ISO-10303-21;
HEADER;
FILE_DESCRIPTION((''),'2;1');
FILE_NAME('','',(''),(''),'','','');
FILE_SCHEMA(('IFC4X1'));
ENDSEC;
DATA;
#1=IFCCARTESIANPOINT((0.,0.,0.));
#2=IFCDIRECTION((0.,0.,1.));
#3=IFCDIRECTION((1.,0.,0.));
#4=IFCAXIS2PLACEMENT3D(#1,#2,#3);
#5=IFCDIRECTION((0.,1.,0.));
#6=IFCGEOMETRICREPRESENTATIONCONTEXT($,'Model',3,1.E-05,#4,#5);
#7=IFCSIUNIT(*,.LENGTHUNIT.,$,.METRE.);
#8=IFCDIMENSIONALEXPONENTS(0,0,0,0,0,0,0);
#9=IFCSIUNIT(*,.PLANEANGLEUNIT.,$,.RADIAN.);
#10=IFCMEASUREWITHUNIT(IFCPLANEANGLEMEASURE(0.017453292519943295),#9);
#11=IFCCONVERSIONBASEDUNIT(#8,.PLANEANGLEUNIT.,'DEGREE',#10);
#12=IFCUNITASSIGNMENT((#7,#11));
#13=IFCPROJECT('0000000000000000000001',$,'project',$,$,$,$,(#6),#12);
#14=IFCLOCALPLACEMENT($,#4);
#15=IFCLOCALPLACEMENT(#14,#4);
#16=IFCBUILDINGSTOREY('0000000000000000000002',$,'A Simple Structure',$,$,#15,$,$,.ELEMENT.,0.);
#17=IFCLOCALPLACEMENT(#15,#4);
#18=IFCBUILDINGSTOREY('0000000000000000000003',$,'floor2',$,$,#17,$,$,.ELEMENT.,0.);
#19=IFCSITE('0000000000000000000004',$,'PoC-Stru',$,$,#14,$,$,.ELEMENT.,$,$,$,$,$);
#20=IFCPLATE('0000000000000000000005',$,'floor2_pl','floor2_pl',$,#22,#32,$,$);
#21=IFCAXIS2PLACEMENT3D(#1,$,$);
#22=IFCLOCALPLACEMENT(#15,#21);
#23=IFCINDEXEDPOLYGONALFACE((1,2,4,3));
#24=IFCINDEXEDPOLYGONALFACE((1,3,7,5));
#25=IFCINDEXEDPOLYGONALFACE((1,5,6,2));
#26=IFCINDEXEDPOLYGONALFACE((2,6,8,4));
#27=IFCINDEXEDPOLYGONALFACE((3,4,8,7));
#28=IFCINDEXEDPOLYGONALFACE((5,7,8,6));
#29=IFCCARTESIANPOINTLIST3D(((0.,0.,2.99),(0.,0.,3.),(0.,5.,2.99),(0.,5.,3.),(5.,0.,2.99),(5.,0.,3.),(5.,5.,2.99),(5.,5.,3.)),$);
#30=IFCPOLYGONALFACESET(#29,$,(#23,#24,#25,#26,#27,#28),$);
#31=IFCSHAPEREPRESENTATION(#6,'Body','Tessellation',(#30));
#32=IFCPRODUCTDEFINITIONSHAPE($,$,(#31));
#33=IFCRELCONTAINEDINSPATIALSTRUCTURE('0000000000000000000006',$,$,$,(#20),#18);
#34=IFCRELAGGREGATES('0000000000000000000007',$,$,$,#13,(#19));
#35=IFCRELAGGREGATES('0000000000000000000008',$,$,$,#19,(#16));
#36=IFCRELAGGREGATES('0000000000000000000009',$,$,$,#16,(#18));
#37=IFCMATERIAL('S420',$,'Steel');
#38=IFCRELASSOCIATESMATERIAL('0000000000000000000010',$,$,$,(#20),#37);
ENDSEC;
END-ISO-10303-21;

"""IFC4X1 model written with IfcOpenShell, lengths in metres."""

from ifc_helpers import new_model, entity, si_unit, converted_unit, direction, origin_with_axes, place, context, project, spatial, line, indexed_curve, outline, extrude, material, element, save


model = new_model("IFC4X1")

# Units and contexts
model_context = context("Model", 3, precision=1e-05, world=origin_with_axes(), true_north=direction((0.0, 1.0, 0.0)))
ifc_project = project(units=[si_unit("LENGTHUNIT", "METRE"), converted_unit("PLANEANGLEUNIT", "DEGREE", entity("IfcPlaneAngleMeasure", 0.017453292519943295), si_unit("PLANEANGLEUNIT", "RADIAN"), dimensions=[0, 0, 0, 0, 0, 0, 0])], contexts=[model_context])

# Site, storeys
site_placement = place(None, origin_with_axes())
site = spatial("IfcSite", under=ifc_project, at=site_placement, Name="PoC-Stru", CompositionType="ELEMENT")
storey_1_placement = place(site_placement, origin_with_axes())
storey_1 = spatial("IfcBuildingStorey", under=site, at=storey_1_placement, Name="A Simple Structure", CompositionType="ELEMENT", Elevation=0.0)
storey_2_placement = place(storey_1_placement, origin_with_axes())
storey_2 = spatial("IfcBuildingStorey", under=storey_1, at=storey_2_placement, Name="floor2", CompositionType="ELEMENT", Elevation=0.0)

# Plate
ifc_material = material(Name="S420", Category="Steel")
plate_placement = place(storey_2_placement, origin_with_axes())
element("IfcPlate", 1, at=plate_placement, inside=storey_2, material=ifc_material, Name="floor2_pl", Description="floor2_pl", context=model_context, shape_type="SolidModel", body=[
    extrude(outline(indexed_curve([(0.0, 5.0, 3.0), (0.0, 0.0, 3.0), (5.0, 0.0, 3.0), (5.0, 5.0, 3.0)], segments=[line(1, 2), line(2, 3), line(3, 4), line(4, 1)])), origin_with_axes(), (0.0, 0.0, -1.0), 0.01),
])

save(model, "model.ifc")
